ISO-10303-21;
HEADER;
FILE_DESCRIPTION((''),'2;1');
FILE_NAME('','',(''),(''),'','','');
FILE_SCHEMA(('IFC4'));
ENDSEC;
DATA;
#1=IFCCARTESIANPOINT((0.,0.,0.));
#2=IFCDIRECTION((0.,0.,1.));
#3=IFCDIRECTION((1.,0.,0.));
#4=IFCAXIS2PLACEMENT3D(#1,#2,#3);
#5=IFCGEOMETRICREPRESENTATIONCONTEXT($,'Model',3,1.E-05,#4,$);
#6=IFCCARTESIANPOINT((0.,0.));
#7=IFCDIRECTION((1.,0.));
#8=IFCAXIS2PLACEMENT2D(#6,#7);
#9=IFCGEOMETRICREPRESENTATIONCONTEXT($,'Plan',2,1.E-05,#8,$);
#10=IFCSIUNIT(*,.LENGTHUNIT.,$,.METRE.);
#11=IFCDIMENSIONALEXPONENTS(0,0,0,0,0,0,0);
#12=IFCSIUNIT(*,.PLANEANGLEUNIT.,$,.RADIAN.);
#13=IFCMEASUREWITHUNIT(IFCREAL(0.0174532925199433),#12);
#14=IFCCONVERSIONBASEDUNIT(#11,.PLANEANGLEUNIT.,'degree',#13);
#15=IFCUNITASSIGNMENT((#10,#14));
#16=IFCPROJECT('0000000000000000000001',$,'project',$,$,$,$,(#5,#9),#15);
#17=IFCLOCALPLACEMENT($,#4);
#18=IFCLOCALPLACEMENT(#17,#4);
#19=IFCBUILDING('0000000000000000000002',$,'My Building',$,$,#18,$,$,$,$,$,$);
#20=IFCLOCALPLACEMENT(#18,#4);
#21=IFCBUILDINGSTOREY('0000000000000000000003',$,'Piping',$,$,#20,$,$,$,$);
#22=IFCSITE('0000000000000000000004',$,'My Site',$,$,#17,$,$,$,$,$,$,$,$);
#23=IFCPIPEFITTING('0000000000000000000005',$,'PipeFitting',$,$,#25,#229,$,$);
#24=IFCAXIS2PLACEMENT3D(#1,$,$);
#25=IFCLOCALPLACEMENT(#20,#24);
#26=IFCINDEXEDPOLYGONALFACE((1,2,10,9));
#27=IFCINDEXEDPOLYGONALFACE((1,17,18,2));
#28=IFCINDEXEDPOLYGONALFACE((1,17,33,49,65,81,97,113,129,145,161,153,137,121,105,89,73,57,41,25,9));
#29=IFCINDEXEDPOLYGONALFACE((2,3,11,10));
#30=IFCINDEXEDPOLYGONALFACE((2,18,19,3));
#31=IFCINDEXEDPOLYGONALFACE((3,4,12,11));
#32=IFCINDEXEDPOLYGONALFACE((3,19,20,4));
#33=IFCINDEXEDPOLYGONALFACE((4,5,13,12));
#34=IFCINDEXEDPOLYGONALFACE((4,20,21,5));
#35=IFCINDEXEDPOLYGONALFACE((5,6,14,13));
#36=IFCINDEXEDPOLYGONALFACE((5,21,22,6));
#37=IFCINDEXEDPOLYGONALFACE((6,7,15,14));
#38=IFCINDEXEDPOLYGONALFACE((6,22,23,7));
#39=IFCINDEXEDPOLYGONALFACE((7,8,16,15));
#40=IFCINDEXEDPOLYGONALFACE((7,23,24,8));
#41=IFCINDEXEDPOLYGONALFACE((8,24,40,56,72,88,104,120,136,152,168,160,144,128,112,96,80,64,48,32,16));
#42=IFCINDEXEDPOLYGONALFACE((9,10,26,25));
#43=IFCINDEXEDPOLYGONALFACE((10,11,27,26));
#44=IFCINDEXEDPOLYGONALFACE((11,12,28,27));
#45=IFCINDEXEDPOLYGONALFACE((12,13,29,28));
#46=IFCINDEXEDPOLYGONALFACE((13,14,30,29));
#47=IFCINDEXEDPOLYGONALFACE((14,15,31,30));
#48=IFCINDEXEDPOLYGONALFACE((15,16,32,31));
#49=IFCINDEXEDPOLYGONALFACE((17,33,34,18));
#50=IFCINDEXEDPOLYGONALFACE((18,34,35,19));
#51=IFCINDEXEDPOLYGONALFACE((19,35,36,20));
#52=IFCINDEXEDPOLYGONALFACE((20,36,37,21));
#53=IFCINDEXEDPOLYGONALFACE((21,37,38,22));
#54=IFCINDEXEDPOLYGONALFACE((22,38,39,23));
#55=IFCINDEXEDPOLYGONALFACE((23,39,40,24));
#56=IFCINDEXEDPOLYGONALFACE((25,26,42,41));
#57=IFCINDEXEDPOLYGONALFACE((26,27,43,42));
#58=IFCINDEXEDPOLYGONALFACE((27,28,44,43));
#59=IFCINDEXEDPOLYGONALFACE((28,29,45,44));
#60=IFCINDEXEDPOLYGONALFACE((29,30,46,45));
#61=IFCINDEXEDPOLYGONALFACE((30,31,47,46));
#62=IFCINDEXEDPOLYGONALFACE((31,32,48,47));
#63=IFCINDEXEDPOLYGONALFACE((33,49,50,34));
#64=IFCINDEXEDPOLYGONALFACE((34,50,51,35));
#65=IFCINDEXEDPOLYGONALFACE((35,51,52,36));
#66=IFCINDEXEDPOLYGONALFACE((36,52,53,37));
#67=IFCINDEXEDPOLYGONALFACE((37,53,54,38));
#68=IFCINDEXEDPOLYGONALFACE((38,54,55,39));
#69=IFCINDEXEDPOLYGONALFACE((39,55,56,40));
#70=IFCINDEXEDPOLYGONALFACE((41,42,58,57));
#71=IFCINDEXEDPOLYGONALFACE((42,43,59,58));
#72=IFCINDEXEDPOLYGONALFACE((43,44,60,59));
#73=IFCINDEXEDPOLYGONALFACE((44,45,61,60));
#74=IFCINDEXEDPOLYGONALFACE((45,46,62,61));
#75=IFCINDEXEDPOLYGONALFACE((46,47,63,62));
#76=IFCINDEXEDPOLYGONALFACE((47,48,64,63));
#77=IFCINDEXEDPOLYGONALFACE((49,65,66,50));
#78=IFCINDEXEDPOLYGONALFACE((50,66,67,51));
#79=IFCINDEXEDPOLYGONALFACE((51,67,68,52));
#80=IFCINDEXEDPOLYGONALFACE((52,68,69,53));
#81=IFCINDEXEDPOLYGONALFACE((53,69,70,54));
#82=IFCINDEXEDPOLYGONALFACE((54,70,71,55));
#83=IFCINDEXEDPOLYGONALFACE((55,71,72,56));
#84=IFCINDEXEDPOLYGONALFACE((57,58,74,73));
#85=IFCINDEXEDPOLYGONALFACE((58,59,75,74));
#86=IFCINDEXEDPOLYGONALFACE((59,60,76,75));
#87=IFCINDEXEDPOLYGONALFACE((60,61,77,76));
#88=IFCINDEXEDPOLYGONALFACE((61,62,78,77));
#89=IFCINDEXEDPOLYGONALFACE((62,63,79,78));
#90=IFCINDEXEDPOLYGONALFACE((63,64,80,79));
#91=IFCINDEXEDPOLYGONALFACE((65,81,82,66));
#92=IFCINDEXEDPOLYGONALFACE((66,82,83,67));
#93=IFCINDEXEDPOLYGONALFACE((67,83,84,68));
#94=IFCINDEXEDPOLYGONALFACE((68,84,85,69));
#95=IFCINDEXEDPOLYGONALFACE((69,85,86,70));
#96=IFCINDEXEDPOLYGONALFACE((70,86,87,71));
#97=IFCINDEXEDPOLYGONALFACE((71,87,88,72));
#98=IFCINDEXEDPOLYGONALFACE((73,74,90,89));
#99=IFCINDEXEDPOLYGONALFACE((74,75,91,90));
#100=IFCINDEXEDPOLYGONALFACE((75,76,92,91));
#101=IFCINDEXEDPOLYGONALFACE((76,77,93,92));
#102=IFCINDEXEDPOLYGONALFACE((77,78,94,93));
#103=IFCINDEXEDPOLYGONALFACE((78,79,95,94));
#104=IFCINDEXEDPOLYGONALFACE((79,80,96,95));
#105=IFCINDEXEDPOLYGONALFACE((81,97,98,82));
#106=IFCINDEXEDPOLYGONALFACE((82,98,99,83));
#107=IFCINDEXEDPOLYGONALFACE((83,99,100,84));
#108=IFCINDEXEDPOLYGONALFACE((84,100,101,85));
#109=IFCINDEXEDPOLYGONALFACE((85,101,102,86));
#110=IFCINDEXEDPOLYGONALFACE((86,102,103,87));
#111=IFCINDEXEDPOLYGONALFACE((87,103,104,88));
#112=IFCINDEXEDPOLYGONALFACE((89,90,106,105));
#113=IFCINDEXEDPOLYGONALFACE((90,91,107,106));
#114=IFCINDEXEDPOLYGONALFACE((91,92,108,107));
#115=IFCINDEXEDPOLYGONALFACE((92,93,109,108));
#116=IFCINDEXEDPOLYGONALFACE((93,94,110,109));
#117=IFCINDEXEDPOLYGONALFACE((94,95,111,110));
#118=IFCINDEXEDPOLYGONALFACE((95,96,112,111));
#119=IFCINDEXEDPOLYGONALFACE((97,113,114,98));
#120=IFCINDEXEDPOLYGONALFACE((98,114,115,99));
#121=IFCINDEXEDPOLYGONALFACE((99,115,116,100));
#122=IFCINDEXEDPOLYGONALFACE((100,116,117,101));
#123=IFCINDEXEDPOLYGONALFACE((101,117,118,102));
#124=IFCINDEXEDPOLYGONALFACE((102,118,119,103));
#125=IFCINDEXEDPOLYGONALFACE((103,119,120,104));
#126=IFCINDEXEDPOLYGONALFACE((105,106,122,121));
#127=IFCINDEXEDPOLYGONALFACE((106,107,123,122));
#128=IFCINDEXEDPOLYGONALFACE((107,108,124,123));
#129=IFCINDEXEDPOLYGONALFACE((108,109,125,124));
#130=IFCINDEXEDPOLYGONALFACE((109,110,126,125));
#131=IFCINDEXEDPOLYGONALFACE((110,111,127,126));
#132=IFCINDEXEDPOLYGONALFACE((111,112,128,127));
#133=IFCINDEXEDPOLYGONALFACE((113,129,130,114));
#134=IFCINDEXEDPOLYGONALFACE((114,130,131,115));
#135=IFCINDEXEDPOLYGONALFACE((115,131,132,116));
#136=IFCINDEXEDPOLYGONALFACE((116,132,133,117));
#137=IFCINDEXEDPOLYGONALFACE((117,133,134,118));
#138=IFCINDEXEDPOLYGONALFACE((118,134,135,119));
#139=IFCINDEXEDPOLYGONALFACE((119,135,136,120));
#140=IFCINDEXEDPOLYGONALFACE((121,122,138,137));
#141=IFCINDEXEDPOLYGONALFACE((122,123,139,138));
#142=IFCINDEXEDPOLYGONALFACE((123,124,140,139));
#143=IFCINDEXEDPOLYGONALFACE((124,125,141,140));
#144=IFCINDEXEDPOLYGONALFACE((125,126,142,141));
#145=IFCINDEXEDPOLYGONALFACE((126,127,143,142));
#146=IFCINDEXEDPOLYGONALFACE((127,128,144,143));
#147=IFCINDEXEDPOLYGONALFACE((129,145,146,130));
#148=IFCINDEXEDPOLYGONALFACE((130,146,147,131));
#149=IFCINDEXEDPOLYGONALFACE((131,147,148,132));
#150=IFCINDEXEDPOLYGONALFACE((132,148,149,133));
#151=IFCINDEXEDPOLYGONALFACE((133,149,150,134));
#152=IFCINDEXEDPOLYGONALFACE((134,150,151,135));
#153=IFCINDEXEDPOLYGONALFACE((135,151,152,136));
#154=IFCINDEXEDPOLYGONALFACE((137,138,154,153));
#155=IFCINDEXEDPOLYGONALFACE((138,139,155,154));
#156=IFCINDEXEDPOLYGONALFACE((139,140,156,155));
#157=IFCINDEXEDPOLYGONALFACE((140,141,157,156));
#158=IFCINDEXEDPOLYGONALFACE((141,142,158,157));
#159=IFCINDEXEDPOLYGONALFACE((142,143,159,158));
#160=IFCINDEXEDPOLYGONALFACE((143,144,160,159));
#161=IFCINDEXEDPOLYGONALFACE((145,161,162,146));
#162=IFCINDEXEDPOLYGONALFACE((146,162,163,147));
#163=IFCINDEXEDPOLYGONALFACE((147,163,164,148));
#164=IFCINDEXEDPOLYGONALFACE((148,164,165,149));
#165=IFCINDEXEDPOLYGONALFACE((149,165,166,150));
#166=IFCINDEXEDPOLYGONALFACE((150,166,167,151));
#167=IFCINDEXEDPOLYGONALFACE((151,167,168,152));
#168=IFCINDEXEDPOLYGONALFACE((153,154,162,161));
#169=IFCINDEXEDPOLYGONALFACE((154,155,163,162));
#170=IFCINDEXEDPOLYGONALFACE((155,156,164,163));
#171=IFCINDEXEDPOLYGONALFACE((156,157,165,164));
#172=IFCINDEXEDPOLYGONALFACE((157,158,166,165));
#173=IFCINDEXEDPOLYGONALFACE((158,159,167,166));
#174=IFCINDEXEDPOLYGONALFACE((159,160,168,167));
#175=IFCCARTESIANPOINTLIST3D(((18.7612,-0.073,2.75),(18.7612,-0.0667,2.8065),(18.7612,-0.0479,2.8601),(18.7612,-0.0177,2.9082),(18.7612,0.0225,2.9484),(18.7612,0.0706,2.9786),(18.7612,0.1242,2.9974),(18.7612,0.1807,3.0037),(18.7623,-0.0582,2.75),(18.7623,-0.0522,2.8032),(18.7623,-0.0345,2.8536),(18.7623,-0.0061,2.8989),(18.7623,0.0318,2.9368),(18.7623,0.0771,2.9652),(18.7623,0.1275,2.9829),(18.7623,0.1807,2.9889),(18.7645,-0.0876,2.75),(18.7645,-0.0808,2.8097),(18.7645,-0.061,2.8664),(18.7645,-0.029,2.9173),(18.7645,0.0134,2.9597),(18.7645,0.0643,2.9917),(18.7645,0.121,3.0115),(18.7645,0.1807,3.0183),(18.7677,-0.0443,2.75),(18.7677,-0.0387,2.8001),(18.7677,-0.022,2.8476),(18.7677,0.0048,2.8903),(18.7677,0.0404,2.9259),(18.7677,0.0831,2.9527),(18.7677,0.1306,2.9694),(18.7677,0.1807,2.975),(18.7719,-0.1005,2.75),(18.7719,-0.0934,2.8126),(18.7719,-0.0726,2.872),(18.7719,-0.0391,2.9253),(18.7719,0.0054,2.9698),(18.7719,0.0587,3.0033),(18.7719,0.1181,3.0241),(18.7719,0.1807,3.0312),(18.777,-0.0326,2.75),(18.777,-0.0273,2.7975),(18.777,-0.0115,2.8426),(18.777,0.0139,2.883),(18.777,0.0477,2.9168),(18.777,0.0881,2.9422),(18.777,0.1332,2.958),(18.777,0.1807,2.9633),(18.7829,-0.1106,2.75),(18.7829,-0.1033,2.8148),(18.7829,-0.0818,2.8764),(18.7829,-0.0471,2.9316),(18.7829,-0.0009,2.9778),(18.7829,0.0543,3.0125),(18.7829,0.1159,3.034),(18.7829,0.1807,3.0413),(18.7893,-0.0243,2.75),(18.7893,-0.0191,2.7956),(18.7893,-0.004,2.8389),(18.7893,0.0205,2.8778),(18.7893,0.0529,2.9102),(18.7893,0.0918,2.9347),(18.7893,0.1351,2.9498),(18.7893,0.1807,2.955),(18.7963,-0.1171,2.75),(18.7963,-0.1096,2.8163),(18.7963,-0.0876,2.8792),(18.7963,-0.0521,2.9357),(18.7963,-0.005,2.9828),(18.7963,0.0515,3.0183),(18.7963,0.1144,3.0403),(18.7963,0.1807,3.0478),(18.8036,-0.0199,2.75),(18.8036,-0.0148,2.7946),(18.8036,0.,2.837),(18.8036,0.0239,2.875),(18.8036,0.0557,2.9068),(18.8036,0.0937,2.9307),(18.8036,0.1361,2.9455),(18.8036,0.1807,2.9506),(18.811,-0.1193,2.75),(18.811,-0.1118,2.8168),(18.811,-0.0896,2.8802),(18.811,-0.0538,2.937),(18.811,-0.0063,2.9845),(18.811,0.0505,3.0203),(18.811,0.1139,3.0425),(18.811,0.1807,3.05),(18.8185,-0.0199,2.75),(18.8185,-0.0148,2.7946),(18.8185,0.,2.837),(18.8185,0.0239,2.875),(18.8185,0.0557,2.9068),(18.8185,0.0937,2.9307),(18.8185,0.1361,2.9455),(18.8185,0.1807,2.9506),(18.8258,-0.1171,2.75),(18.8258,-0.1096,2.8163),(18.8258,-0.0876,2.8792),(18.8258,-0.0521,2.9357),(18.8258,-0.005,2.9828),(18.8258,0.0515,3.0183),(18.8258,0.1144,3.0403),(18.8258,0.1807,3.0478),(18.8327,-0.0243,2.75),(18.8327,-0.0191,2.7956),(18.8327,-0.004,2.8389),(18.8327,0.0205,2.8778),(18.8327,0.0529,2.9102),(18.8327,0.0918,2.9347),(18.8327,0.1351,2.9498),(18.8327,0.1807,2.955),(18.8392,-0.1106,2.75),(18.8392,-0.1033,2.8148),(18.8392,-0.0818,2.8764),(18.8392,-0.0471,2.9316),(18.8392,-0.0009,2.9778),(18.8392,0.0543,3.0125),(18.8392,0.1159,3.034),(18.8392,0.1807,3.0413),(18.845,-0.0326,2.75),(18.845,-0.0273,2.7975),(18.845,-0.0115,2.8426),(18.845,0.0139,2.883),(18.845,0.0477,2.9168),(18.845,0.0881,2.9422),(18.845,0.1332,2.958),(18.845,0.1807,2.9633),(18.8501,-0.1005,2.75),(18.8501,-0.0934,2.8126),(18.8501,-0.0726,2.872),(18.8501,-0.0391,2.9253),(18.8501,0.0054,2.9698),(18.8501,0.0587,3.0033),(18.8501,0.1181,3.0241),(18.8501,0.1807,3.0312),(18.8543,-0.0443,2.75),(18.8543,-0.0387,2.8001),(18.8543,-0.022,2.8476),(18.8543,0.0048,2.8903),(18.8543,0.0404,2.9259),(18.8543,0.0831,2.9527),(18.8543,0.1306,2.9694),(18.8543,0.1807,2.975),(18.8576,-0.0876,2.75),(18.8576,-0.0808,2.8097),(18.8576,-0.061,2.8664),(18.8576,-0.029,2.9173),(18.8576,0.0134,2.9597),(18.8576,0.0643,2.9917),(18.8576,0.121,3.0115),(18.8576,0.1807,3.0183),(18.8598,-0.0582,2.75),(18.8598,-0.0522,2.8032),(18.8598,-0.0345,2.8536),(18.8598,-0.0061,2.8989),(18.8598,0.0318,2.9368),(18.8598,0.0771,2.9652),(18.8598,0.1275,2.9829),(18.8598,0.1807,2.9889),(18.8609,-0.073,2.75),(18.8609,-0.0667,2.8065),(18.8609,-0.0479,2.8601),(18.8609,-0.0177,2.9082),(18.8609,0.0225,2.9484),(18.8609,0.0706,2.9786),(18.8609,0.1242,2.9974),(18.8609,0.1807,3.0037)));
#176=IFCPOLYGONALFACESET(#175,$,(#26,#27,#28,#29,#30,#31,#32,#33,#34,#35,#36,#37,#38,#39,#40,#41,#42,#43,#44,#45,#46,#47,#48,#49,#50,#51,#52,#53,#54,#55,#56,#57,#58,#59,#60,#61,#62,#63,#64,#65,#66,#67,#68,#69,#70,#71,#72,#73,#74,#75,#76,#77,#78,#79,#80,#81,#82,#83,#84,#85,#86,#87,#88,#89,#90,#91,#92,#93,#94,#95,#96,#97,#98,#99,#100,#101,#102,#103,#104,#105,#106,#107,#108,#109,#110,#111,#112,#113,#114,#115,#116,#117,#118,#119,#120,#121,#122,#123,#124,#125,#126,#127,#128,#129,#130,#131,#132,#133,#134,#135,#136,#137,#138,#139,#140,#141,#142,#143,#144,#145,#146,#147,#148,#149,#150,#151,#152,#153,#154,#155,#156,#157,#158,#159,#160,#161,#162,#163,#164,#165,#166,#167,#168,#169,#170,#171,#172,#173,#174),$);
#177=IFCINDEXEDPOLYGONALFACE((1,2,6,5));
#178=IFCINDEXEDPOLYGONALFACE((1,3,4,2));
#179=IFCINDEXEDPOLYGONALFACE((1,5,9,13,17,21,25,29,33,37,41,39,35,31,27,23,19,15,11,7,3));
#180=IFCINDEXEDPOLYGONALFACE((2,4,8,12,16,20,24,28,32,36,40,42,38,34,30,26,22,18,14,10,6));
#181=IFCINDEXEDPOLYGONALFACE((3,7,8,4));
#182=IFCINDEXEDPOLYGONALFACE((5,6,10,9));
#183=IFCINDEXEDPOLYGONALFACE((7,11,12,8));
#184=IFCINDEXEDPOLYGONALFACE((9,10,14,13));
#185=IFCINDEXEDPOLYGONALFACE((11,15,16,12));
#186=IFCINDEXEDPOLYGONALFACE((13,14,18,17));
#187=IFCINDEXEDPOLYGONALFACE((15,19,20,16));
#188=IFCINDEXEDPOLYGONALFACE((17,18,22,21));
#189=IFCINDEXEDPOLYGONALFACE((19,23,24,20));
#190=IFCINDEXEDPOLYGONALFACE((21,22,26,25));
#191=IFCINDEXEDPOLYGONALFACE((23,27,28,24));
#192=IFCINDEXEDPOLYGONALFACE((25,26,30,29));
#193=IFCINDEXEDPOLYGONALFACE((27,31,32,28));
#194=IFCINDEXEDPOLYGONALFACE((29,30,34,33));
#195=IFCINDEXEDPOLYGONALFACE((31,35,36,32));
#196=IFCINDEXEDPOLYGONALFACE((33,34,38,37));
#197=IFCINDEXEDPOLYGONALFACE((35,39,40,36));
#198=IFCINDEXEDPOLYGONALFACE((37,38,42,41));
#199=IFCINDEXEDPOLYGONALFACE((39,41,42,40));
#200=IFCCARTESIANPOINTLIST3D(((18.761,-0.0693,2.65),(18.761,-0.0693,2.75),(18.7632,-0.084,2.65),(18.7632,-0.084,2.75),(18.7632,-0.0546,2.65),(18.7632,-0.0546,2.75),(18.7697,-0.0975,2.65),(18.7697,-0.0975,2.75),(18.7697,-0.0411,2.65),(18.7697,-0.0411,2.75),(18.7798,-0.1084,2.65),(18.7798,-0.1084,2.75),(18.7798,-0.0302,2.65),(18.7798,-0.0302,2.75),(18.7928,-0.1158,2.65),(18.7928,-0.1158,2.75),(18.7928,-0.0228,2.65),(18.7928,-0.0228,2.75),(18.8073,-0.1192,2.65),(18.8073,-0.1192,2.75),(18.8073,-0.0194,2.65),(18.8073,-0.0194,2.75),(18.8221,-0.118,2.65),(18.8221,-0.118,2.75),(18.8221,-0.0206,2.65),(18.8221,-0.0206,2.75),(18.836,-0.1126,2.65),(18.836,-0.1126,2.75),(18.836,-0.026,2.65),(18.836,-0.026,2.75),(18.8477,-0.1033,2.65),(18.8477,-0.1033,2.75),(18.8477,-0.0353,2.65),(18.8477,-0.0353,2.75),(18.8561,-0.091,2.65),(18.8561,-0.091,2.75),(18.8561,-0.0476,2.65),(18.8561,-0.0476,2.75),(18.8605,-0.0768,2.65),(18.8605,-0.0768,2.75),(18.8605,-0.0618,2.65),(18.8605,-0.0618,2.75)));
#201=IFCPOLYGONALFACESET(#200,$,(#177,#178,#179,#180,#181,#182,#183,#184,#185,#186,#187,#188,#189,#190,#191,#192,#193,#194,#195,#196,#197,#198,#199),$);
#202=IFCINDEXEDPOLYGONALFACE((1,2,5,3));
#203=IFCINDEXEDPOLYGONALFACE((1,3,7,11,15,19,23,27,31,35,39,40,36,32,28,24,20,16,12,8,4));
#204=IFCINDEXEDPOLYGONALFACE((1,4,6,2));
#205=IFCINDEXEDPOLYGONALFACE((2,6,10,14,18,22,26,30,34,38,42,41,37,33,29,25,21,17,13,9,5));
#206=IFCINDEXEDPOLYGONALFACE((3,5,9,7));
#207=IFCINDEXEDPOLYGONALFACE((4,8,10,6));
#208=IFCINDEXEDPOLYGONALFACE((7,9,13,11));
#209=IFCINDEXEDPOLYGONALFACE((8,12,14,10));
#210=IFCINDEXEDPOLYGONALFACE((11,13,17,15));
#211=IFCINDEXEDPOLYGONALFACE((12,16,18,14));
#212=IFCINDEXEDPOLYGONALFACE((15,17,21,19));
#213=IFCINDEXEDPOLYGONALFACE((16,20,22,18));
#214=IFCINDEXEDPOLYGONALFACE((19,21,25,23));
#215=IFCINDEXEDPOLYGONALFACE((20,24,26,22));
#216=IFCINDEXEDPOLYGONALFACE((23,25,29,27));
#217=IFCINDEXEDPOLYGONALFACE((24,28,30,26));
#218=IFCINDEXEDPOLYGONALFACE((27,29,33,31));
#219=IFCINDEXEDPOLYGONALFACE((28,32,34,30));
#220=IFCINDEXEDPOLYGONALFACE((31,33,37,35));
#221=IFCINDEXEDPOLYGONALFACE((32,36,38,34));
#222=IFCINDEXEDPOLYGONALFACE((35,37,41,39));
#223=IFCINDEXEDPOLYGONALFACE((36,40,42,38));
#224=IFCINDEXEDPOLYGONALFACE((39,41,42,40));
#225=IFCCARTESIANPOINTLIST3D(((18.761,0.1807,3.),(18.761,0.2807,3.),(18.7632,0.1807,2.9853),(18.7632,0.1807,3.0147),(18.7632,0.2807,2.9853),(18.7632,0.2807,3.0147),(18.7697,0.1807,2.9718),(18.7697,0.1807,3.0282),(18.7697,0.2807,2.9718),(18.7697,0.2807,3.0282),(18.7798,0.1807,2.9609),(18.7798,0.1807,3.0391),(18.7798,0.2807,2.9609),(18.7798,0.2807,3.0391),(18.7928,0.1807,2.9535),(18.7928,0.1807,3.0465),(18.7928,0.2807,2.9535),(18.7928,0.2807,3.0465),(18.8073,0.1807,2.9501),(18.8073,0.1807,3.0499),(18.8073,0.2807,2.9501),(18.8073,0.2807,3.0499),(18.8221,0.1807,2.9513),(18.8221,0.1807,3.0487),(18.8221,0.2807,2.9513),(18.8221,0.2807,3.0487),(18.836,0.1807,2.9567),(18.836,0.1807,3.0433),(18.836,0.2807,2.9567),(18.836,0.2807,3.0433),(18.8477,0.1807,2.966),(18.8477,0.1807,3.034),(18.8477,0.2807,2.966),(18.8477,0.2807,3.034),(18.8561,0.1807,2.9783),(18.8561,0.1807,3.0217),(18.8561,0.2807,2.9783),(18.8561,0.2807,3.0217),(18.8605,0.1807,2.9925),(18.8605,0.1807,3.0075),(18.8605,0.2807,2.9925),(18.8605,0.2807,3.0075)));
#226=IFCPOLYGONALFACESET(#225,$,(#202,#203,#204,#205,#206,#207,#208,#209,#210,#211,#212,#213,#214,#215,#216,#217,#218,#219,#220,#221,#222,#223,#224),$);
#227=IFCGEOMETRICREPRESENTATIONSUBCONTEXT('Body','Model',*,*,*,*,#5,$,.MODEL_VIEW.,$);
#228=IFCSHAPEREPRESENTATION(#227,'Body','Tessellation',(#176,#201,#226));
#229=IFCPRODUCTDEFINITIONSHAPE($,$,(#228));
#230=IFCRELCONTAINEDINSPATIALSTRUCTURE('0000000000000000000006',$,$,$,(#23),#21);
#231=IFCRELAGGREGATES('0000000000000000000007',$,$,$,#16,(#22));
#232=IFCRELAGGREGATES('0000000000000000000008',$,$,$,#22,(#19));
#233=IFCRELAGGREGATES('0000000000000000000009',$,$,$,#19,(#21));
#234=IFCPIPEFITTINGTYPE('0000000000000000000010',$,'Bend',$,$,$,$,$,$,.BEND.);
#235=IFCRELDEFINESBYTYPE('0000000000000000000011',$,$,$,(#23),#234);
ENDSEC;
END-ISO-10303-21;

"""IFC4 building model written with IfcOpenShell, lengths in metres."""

from ifc_helpers import new_model, entity, si_unit, converted_unit, frame, origin_with_axes, origin_2d_with_axis, place, context, subcontext, project, spatial, circle, extrude, source, transform, mapped, type_object, type_shapes, element, save


model = new_model("IFC4")

# Units and contexts
model_context = context("Model", 3, precision=1e-05, world=origin_with_axes())
plan_context = context("Plan", 2, precision=1e-05, world=origin_2d_with_axis())
body_context = subcontext(model_context, "Body", "Model", "MODEL_VIEW")
ifc_project = project(units=[si_unit("LENGTHUNIT", "METRE"), converted_unit("PLANEANGLEUNIT", "degree", entity("IfcReal", 0.0174532925199433), si_unit("PLANEANGLEUNIT", "RADIAN"), dimensions=[0, 0, 0, 0, 0, 0, 0])], contexts=[model_context, plan_context])

# Site, building, storey
site_placement = place(None, origin_with_axes())
site = spatial("IfcSite", under=ifc_project, at=site_placement, Name="My Site")
building_placement = place(site_placement, origin_with_axes())
building = spatial("IfcBuilding", under=site, at=building_placement, Name="My Building")
storey_placement = place(building_placement, origin_with_axes())
storey = spatial("IfcBuildingStorey", under=building, at=storey_placement, Name="Piping")

# Pipe fitting
pipe_fitting_type_1 = type_object("IfcPipeFittingType", Name="Bend", PredefinedType="BEND")
shared_shape = source(origin_with_axes(), body_context, "Body", "SolidModel", [
    entity("IfcSweptDiskSolid", entity("IfcIndexedPolyCurve", entity("IfcCartesianPointList3D", [[0.0, 0.0, -0.1], [0.0, 0.0732, -0.2768], [0.0, 0.25, -0.35]]), [entity("IfcArcIndex", [1, 2, 3])]), 0.05),
    extrude(circle(Radius=0.05), origin_with_axes(), (0.0, 0.0, -1.0), 0.1),
    extrude(circle(Radius=0.05), frame((0.0, 0.25, -0.35), z_axis=(0.0, 1.0, 0.0), x_axis=(1.0, 0.0, 0.0)), (0.0, 0.0, 1.0), 0.1),
])
type_shapes(pipe_fitting_type_1, [shared_shape])
for number, where, z_axis, x_axis, name in (
    (1, (18.811, -0.0693, 2.65), (0.0, 0.0, -1.0), (-1.0, 0.0, 0.0), "PipeFitting"),
):
    element("IfcPipeFitting", number, at=place(storey_placement, frame(where, z_axis=z_axis, x_axis=x_axis)), inside=storey, type_object=pipe_fitting_type_1, Name=name, context=body_context, shape_type="MappedRepresentation", body=[
        mapped(shared_shape, transform((0.0, 0.0, 0.0), x_axis=(1.0, 0.0, 0.0), y_axis=(0.0, 1.0, 0.0), z_axis=(0.0, 0.0, 1.0), scale=1.0)),
    ])

save(model, "model.ifc")
